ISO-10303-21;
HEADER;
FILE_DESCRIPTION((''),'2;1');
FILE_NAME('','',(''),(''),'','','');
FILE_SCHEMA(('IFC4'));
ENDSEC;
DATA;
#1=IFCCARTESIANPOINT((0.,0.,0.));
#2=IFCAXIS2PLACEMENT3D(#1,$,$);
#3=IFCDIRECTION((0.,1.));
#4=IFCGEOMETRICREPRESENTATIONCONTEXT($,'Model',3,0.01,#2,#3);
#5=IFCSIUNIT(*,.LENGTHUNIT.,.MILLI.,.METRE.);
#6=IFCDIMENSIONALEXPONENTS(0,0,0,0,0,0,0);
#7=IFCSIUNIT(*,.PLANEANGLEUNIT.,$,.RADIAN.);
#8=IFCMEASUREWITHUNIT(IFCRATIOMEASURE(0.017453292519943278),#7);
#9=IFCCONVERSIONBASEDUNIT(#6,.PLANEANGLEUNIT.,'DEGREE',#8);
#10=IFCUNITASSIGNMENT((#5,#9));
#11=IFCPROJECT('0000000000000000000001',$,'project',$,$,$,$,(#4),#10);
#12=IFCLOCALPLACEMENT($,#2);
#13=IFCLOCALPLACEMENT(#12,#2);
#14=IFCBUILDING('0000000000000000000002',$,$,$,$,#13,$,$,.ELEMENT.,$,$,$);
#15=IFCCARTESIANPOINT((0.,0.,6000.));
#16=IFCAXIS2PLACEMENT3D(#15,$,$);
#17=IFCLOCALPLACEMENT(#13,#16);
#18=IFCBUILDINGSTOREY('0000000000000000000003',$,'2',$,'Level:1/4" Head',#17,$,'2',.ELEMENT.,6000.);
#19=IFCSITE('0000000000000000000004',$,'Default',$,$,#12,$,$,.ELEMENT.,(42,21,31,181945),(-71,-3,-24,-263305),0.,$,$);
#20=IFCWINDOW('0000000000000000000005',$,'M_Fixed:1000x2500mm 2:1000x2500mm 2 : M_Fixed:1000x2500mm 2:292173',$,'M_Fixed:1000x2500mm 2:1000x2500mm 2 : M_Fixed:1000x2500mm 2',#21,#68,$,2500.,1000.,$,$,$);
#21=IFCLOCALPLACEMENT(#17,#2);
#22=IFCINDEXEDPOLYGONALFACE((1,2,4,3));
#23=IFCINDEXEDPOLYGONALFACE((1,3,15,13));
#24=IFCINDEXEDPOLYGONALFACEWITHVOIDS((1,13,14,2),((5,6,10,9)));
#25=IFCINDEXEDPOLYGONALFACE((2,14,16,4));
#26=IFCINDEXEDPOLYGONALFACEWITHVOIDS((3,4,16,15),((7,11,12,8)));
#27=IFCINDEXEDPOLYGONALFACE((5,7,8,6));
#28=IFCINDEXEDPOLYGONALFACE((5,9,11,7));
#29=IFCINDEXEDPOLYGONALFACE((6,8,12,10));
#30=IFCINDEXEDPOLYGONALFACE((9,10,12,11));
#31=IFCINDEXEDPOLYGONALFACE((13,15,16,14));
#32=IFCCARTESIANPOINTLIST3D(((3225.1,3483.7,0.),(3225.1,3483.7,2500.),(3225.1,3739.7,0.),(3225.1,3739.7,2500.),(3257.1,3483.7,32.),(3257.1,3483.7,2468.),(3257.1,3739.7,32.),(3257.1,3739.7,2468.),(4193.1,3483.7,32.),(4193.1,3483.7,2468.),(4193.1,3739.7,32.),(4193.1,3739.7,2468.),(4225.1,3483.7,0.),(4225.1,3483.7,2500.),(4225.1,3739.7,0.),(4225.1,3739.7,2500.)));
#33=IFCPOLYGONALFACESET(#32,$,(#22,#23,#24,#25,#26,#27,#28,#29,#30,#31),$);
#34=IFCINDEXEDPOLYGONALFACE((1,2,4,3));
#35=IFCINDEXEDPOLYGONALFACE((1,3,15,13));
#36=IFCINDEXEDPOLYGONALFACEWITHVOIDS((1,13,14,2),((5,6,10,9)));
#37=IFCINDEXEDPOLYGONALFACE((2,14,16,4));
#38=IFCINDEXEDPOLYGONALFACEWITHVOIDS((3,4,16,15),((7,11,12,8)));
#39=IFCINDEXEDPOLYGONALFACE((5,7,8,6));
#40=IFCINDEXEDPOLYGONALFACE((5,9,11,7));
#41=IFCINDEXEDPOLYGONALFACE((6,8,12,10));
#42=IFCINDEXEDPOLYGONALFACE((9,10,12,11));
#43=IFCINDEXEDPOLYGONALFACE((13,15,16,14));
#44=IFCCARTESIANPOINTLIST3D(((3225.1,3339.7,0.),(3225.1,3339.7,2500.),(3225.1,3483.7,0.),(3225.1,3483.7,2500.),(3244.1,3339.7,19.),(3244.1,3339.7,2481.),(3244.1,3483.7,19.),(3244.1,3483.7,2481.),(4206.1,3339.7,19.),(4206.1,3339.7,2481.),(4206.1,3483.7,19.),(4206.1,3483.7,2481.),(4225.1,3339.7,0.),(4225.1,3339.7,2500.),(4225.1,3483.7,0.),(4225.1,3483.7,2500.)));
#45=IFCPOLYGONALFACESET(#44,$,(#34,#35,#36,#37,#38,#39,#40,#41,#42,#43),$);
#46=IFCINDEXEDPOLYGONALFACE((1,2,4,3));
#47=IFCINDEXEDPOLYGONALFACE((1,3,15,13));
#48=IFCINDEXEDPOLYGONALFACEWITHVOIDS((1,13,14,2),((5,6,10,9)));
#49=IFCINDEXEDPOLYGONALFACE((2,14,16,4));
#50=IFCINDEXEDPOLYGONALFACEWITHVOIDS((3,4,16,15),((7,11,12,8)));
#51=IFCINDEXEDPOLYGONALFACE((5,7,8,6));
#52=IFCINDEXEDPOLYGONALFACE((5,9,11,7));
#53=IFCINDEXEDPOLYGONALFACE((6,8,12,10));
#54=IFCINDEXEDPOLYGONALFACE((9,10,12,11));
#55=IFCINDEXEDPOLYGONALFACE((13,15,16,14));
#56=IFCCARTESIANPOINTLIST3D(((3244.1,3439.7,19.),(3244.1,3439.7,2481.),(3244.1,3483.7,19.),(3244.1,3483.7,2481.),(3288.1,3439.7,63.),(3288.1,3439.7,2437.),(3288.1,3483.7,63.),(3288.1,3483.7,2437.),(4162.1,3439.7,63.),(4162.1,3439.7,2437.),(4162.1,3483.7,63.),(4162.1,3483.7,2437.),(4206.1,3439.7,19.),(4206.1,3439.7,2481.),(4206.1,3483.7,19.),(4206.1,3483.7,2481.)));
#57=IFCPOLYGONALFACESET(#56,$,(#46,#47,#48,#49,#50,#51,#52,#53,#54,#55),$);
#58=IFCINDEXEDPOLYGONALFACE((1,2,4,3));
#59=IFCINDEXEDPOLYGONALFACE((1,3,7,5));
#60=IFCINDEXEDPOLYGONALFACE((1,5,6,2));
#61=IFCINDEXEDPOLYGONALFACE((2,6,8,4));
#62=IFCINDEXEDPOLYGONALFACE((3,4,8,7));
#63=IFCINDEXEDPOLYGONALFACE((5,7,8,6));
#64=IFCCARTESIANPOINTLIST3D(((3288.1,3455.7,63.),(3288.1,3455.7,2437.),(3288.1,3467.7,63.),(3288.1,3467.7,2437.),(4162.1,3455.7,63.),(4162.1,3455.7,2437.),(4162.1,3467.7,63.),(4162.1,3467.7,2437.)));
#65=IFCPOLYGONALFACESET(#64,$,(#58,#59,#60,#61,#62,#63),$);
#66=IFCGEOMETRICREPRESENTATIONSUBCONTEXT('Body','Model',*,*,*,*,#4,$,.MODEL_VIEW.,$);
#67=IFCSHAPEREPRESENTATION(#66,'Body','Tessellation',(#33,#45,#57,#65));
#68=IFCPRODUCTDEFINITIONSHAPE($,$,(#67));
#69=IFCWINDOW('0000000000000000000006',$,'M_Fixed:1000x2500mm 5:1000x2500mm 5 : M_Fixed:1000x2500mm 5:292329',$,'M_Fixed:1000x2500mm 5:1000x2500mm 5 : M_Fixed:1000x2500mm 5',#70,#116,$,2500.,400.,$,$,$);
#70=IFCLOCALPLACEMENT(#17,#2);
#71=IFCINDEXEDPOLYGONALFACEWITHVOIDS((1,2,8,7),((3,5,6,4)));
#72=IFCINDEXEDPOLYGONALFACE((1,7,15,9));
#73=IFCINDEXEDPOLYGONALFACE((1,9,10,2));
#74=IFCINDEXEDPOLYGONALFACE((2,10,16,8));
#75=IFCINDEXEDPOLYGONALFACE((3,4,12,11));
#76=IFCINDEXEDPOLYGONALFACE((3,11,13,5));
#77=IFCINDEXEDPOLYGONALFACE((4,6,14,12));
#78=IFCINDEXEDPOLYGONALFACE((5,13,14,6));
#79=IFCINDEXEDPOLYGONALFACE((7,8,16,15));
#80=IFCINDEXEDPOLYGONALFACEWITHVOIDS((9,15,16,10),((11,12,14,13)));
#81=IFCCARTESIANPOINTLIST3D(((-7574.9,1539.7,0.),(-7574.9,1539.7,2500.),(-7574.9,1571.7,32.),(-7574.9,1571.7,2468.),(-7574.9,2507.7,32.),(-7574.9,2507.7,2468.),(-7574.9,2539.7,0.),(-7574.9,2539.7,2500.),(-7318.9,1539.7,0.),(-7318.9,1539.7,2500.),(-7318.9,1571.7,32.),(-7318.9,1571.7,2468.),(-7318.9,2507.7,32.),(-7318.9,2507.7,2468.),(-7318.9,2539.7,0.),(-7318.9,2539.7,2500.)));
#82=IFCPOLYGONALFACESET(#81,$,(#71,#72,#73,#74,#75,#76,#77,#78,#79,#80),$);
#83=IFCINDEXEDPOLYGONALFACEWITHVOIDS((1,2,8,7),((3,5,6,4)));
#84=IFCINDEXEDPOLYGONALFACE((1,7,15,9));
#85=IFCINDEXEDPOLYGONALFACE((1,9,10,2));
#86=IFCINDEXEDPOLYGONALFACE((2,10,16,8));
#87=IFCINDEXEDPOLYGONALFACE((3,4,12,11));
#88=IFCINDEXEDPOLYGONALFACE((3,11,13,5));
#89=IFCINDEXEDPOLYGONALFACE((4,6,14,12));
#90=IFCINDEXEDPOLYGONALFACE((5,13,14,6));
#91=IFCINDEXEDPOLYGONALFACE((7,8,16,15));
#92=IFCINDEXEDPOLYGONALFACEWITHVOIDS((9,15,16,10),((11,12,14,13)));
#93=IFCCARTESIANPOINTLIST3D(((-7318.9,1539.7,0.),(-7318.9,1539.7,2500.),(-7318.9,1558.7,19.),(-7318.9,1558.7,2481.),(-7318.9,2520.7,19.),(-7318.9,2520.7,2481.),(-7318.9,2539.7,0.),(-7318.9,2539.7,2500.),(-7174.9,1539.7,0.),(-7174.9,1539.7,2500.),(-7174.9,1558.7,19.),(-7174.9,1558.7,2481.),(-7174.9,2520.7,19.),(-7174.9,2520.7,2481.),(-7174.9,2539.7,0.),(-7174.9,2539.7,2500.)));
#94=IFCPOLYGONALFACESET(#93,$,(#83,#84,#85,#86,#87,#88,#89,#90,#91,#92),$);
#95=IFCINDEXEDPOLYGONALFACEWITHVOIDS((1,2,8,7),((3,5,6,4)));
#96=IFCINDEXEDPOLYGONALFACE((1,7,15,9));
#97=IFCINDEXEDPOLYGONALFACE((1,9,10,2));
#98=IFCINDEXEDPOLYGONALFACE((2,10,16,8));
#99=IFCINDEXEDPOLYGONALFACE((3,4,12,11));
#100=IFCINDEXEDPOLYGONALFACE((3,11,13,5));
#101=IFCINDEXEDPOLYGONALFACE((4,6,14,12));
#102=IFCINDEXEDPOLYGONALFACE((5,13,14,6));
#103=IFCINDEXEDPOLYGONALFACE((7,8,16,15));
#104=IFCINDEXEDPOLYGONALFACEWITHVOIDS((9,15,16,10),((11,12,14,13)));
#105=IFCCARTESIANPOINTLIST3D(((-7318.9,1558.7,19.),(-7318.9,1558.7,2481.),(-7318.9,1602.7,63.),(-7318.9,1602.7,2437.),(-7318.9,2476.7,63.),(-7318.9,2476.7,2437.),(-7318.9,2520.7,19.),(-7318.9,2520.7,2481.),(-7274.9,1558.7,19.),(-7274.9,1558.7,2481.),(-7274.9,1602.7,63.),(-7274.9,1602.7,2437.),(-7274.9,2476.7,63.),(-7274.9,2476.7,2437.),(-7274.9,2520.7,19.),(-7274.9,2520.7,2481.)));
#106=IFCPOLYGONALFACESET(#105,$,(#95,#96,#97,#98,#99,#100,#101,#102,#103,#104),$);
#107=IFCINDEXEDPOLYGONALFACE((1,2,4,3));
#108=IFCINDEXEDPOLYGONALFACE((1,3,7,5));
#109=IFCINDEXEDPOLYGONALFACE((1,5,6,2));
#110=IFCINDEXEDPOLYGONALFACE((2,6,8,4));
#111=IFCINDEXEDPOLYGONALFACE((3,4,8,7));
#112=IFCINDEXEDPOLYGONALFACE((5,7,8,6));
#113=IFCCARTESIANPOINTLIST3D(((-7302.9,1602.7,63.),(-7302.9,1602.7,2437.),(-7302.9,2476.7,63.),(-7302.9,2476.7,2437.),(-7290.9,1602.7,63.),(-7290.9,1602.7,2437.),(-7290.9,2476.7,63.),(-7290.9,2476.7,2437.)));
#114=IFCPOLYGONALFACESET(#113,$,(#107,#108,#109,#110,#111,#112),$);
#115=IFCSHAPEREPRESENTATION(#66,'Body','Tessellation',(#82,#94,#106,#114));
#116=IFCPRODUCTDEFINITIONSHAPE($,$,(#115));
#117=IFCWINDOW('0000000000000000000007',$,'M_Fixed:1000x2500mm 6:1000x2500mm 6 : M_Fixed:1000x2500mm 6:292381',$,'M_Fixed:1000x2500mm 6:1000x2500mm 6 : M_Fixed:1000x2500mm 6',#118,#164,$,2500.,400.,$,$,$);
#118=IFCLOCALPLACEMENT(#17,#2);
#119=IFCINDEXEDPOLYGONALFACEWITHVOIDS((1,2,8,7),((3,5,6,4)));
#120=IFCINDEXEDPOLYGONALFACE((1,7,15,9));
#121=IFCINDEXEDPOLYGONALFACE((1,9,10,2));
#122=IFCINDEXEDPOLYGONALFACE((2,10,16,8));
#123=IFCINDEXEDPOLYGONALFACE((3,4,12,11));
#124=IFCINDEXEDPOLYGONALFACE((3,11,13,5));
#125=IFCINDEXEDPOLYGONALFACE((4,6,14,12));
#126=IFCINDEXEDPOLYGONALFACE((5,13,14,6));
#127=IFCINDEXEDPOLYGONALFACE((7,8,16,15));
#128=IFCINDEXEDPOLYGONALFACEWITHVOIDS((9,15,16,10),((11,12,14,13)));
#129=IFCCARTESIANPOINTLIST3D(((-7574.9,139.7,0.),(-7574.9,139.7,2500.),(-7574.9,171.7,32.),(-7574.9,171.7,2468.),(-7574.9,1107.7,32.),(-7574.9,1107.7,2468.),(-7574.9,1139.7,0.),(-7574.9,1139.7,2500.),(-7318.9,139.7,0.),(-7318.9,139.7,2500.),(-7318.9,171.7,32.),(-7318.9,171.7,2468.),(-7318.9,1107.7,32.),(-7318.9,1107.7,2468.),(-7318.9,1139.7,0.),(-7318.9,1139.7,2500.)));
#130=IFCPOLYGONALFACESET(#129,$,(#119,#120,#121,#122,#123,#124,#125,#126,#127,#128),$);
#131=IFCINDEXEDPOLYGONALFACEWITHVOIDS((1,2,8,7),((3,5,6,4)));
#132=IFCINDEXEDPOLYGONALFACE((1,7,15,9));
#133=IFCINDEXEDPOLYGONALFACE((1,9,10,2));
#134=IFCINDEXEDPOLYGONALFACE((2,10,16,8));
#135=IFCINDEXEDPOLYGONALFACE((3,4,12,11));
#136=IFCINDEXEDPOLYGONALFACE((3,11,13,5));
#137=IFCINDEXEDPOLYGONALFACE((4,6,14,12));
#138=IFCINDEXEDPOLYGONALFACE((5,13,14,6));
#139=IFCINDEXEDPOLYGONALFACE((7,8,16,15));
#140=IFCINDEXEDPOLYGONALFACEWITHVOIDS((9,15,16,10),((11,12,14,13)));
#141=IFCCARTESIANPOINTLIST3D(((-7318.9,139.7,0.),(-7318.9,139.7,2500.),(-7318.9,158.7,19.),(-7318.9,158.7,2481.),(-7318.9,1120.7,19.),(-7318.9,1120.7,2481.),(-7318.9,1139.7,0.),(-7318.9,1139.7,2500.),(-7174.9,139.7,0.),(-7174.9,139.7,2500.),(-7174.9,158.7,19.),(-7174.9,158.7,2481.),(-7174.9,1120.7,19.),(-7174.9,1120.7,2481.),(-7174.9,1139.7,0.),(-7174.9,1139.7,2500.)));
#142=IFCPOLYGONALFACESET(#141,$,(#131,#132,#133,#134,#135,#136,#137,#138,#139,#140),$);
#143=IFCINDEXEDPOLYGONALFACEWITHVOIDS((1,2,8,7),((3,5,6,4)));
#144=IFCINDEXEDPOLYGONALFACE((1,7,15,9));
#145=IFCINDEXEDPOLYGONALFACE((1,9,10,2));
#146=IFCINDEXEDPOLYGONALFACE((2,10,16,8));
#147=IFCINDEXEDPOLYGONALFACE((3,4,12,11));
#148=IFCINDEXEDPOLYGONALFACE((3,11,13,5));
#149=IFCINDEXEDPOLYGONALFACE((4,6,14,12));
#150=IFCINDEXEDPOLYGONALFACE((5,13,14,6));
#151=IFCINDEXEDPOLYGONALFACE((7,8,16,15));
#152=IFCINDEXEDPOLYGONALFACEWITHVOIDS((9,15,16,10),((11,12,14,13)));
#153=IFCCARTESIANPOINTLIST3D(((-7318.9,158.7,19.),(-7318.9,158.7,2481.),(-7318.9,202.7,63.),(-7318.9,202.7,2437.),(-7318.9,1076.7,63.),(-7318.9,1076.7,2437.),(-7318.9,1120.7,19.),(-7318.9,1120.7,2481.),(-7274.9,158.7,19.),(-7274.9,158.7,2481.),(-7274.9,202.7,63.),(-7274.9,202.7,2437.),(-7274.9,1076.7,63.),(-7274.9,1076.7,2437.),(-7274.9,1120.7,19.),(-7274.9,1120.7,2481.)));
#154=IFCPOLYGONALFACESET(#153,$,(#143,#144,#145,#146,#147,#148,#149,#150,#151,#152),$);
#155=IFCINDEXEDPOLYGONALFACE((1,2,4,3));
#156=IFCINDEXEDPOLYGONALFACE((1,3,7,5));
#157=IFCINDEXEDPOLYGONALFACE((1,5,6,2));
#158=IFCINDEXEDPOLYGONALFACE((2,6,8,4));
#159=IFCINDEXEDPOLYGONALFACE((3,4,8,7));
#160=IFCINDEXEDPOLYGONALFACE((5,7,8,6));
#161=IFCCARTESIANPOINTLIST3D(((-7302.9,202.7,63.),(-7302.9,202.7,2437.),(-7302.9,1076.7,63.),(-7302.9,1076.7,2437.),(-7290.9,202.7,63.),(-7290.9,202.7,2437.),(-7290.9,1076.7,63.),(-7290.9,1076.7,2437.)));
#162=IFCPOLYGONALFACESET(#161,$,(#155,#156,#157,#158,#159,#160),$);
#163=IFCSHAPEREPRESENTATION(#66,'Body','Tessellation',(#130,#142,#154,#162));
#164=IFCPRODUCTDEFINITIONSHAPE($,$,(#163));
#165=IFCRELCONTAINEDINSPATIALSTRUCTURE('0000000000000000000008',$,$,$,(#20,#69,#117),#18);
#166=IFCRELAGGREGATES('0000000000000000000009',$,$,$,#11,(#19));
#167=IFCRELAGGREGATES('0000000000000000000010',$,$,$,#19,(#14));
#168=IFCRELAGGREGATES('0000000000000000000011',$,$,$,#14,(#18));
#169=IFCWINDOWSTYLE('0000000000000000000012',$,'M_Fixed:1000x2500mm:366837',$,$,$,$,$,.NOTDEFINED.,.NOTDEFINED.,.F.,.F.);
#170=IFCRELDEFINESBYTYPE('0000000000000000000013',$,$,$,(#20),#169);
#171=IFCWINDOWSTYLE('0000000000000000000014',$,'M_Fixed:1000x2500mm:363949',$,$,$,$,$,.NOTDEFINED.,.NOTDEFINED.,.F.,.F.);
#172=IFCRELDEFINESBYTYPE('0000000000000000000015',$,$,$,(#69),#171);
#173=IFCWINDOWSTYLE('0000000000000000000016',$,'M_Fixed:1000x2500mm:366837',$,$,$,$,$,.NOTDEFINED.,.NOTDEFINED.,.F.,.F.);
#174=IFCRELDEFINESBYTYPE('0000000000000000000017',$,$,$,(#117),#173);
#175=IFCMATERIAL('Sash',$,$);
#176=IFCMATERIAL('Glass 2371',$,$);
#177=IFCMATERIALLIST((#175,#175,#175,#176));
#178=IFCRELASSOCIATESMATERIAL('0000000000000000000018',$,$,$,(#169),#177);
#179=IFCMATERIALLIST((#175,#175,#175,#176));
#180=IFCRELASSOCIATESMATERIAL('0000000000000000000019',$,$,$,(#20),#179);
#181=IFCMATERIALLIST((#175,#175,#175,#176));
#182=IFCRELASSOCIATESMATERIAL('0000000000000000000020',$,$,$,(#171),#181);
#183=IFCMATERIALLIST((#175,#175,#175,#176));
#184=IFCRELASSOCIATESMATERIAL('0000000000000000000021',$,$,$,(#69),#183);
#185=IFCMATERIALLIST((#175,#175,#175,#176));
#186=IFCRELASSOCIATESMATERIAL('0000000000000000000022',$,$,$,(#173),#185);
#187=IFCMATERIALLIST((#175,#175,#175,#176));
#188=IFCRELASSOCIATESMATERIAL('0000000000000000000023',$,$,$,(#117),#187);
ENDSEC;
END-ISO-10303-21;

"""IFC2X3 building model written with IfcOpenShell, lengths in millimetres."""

from ifc_helpers import new_model, entity, si_unit, converted_unit, direction, frame, frame_2d, origin, origin_2d_with_axis, place, context, subcontext, project, spatial, polyline, rectangle, outline, extrude, source, transform, mapped, material, material_list, type_object, type_shapes, element, save


model = new_model("IFC2X3")

# Units and contexts
model_context = context("Model", 3, precision=0.01, world=origin(), true_north=direction((0.0, 1.0)))
body_context = subcontext(model_context, "Body", "Model", "MODEL_VIEW")
ifc_project = project(units=[si_unit("LENGTHUNIT", "METRE", prefix="MILLI"), converted_unit("PLANEANGLEUNIT", "DEGREE", entity("IfcRatioMeasure", 0.017453292519943278), si_unit("PLANEANGLEUNIT", "RADIAN"), dimensions=[0, 0, 0, 0, 0, 0, 0])], contexts=[model_context])

# Site, building, storey
site_placement = place(None, origin())
site = spatial("IfcSite", under=ifc_project, at=site_placement, Name="Default", CompositionType="ELEMENT", RefLatitude=(42, 21, 31, 181945), RefLongitude=(-71, -3, -24, -263305), RefElevation=0.0)
building_placement = place(site_placement, origin())
building = spatial("IfcBuilding", under=site, at=building_placement, CompositionType="ELEMENT")
storey_placement = place(building_placement, frame((0.0, 0.0, 6000.0)))
storey = spatial("IfcBuildingStorey", under=building, at=storey_placement, Name="2", ObjectType="Level:1/4\" Head", LongName="2", CompositionType="ELEMENT", Elevation=6000.0)

# Windows
ifc_material_1 = material(Name="Sash")
ifc_material_2 = material(Name="Glass 2371")
ifc_material_list_1 = material_list([ifc_material_1, ifc_material_1, ifc_material_1, ifc_material_2])
ifc_material_list_2 = material_list([ifc_material_1, ifc_material_1, ifc_material_1, ifc_material_2])
window_style_1 = type_object("IfcWindowStyle", Name="M_Fixed:1000x2500mm:366837", ConstructionType="NOTDEFINED", OperationType="NOTDEFINED", ParameterTakesPrecedence=False, Sizeable=False, material=ifc_material_list_2)
shared_shape_1 = source(origin(), body_context, "Body", "SweptSolid", [
    extrude(outline(polyline([(-500.0, -1250.0), (500.0, -1250.0), (500.0, 1250.0), (-500.0, 1250.0), (-500.0, -1250.0)]), holes=[polyline([(468.0, 1218.0), (468.0, -1218.0), (-468.0, -1218.0), (-468.0, 1218.0), (468.0, 1218.0)])]), frame((3725.1, 3483.7, 7250.0), z_axis=(0.0, 1.0, 0.0), x_axis=(1.0, 0.0, 0.0)), (0.0, 0.0, 1.0), 256.0),
    extrude(outline(polyline([(-500.0, -1250.0), (500.0, -1250.0), (500.0, 1250.0), (-500.0, 1250.0), (-500.0, -1250.0)]), holes=[polyline([(481.0, 1231.0), (481.0, -1231.0), (-481.0, -1231.0), (-481.0, 1231.0), (481.0, 1231.0)])]), frame((3725.1, 3339.7, 7250.0), z_axis=(0.0, 1.0, 0.0), x_axis=(1.0, 0.0, 0.0)), (0.0, 0.0, 1.0), 144.0),
    extrude(outline(polyline([(-481.0, -1231.0), (481.0, -1231.0), (481.0, 1231.0), (-481.0, 1231.0), (-481.0, -1231.0)]), holes=[polyline([(437.0, 1187.0), (437.0, -1187.0), (-437.0, -1187.0), (-437.0, 1187.0), (437.0, 1187.0)])]), frame((3725.1, 3439.7, 7250.0), z_axis=(0.0, 1.0, 0.0), x_axis=(1.0, 0.0, 0.0)), (0.0, 0.0, 1.0), 44.0),
    extrude(rectangle(XDim=874.0, YDim=12.0, at=frame_2d((0.0, 0.0), x_axis=(1.0, 0.0))), frame((3725.1, 3461.7, 6063.0), z_axis=(0.0, 0.0, 1.0), x_axis=(-1.0, 0.0, 0.0)), (0.0, 0.0, 1.0), 2374.0),
])
type_shapes(window_style_1, [shared_shape_1])
window_1_placement = place(storey_placement, frame((0.0, 0.0, -6000.0)))
element("IfcWindow", 1, at=window_1_placement, inside=storey, type_object=window_style_1, material=ifc_material_list_1, Name="M_Fixed:1000x2500mm 2:1000x2500mm 2 : M_Fixed:1000x2500mm 2:292173", ObjectType="M_Fixed:1000x2500mm 2:1000x2500mm 2 : M_Fixed:1000x2500mm 2", OverallHeight=2500.0, OverallWidth=1000.0, context=body_context, shape_type="MappedRepresentation", body=[
    mapped(shared_shape_1, transform((0.0, 0.0, 0.0), scale=1.0)),
])
ifc_material_list_3 = material_list([ifc_material_1, ifc_material_1, ifc_material_1, ifc_material_2])
ifc_material_list_4 = material_list([ifc_material_1, ifc_material_1, ifc_material_1, ifc_material_2])
window_style_2 = type_object("IfcWindowStyle", Name="M_Fixed:1000x2500mm:363949", ConstructionType="NOTDEFINED", OperationType="NOTDEFINED", ParameterTakesPrecedence=False, Sizeable=False, material=ifc_material_list_4)
shared_shape_2 = source(origin(), body_context, "Body", "SweptSolid", [
    extrude(outline(polyline([(-500.0, -1250.0), (500.0, -1250.0), (500.0, 1250.0), (-500.0, 1250.0), (-500.0, -1250.0)]), holes=[polyline([(468.0, 1218.0), (468.0, -1218.0), (-468.0, -1218.0), (-468.0, 1218.0), (468.0, 1218.0)])]), frame((-7574.9, 2039.7, 7250.0), z_axis=(1.0, 0.0, 0.0), x_axis=(0.0, -1.0, 0.0)), (0.0, 0.0, 1.0), 256.0),
    extrude(outline(polyline([(-500.0, -1250.0), (500.0, -1250.0), (500.0, 1250.0), (-500.0, 1250.0), (-500.0, -1250.0)]), holes=[polyline([(481.0, 1231.0), (481.0, -1231.0), (-481.0, -1231.0), (-481.0, 1231.0), (481.0, 1231.0)])]), frame((-7318.9, 2039.7, 7250.0), z_axis=(1.0, 0.0, 0.0), x_axis=(0.0, -1.0, 0.0)), (0.0, 0.0, 1.0), 144.0),
    extrude(outline(polyline([(-481.0, -1231.0), (481.0, -1231.0), (481.0, 1231.0), (-481.0, 1231.0), (-481.0, -1231.0)]), holes=[polyline([(437.0, 1187.0), (437.0, -1187.0), (-437.0, -1187.0), (-437.0, 1187.0), (437.0, 1187.0)])]), frame((-7318.9, 2039.7, 7250.0), z_axis=(1.0, 0.0, 0.0), x_axis=(0.0, -1.0, 0.0)), (0.0, 0.0, 1.0), 44.0),
    extrude(rectangle(XDim=12.0, YDim=874.0, at=origin_2d_with_axis()), frame((-7296.9, 2039.7, 6063.0), z_axis=(0.0, 0.0, 1.0), x_axis=(-1.0, 0.0, 0.0)), (0.0, 0.0, 1.0), 2374.0),
])
type_shapes(window_style_2, [shared_shape_2])
window_2_placement = place(storey_placement, frame((0.0, 0.0, -6000.0)))
element("IfcWindow", 2, at=window_2_placement, inside=storey, type_object=window_style_2, material=ifc_material_list_3, Name="M_Fixed:1000x2500mm 5:1000x2500mm 5 : M_Fixed:1000x2500mm 5:292329", ObjectType="M_Fixed:1000x2500mm 5:1000x2500mm 5 : M_Fixed:1000x2500mm 5", OverallHeight=2500.0, OverallWidth=400.0, context=body_context, shape_type="MappedRepresentation", body=[
    mapped(shared_shape_2, transform((0.0, 0.0, 0.0), scale=1.0)),
])
ifc_material_list_5 = material_list([ifc_material_1, ifc_material_1, ifc_material_1, ifc_material_2])
ifc_material_list_6 = material_list([ifc_material_1, ifc_material_1, ifc_material_1, ifc_material_2])
window_style_3 = type_object("IfcWindowStyle", Name="M_Fixed:1000x2500mm:366837", ConstructionType="NOTDEFINED", OperationType="NOTDEFINED", ParameterTakesPrecedence=False, Sizeable=False, material=ifc_material_list_6)
shared_shape_3 = source(origin(), body_context, "Body", "SweptSolid", [
    extrude(outline(polyline([(-1250.0, -500.0), (1250.0, -500.0), (1250.0, 500.0), (-1250.0, 500.0), (-1250.0, -500.0)]), holes=[polyline([(1218.0, 468.0), (1218.0, -468.0), (-1218.0, -468.0), (-1218.0, 468.0), (1218.0, 468.0)])]), frame((-7574.9, 639.7, 7250.0), z_axis=(1.0, 0.0, 0.0), x_axis=(0.0, 0.0, -1.0)), (0.0, 0.0, 1.0), 256.0),
    extrude(outline(polyline([(-1250.0, -500.0), (1250.0, -500.0), (1250.0, 500.0), (-1250.0, 500.0), (-1250.0, -500.0)]), holes=[polyline([(1231.0, 481.0), (1231.0, -481.0), (-1231.0, -481.0), (-1231.0, 481.0), (1231.0, 481.0)])]), frame((-7318.9, 639.7, 7250.0), z_axis=(1.0, 0.0, 0.0), x_axis=(0.0, 0.0, -1.0)), (0.0, 0.0, 1.0), 144.0),
    extrude(outline(polyline([(-1231.0, -481.0), (1231.0, -481.0), (1231.0, 481.0), (-1231.0, 481.0), (-1231.0, -481.0)]), holes=[polyline([(1187.0, 437.0), (1187.0, -437.0), (-1187.0, -437.0), (-1187.0, 437.0), (1187.0, 437.0)])]), frame((-7318.9, 639.7, 7250.0), z_axis=(1.0, 0.0, 0.0), x_axis=(0.0, 0.0, -1.0)), (0.0, 0.0, 1.0), 44.0),
    extrude(rectangle(XDim=874.0, YDim=12.0, at=frame_2d((0.0, 0.0), x_axis=(1.0, 0.0))), frame((-7296.9, 639.7, 6063.0), z_axis=(0.0, 0.0, 1.0), x_axis=(0.0, -1.0, 0.0)), (0.0, 0.0, 1.0), 2374.0),
])
type_shapes(window_style_3, [shared_shape_3])
window_3_placement = place(storey_placement, frame((0.0, 0.0, -6000.0)))
element("IfcWindow", 3, at=window_3_placement, inside=storey, type_object=window_style_3, material=ifc_material_list_5, Name="M_Fixed:1000x2500mm 6:1000x2500mm 6 : M_Fixed:1000x2500mm 6:292381", ObjectType="M_Fixed:1000x2500mm 6:1000x2500mm 6 : M_Fixed:1000x2500mm 6", OverallHeight=2500.0, OverallWidth=400.0, context=body_context, shape_type="MappedRepresentation", body=[
    mapped(shared_shape_3, transform((0.0, 0.0, 0.0), scale=1.0)),
])

save(model, "model.ifc")
